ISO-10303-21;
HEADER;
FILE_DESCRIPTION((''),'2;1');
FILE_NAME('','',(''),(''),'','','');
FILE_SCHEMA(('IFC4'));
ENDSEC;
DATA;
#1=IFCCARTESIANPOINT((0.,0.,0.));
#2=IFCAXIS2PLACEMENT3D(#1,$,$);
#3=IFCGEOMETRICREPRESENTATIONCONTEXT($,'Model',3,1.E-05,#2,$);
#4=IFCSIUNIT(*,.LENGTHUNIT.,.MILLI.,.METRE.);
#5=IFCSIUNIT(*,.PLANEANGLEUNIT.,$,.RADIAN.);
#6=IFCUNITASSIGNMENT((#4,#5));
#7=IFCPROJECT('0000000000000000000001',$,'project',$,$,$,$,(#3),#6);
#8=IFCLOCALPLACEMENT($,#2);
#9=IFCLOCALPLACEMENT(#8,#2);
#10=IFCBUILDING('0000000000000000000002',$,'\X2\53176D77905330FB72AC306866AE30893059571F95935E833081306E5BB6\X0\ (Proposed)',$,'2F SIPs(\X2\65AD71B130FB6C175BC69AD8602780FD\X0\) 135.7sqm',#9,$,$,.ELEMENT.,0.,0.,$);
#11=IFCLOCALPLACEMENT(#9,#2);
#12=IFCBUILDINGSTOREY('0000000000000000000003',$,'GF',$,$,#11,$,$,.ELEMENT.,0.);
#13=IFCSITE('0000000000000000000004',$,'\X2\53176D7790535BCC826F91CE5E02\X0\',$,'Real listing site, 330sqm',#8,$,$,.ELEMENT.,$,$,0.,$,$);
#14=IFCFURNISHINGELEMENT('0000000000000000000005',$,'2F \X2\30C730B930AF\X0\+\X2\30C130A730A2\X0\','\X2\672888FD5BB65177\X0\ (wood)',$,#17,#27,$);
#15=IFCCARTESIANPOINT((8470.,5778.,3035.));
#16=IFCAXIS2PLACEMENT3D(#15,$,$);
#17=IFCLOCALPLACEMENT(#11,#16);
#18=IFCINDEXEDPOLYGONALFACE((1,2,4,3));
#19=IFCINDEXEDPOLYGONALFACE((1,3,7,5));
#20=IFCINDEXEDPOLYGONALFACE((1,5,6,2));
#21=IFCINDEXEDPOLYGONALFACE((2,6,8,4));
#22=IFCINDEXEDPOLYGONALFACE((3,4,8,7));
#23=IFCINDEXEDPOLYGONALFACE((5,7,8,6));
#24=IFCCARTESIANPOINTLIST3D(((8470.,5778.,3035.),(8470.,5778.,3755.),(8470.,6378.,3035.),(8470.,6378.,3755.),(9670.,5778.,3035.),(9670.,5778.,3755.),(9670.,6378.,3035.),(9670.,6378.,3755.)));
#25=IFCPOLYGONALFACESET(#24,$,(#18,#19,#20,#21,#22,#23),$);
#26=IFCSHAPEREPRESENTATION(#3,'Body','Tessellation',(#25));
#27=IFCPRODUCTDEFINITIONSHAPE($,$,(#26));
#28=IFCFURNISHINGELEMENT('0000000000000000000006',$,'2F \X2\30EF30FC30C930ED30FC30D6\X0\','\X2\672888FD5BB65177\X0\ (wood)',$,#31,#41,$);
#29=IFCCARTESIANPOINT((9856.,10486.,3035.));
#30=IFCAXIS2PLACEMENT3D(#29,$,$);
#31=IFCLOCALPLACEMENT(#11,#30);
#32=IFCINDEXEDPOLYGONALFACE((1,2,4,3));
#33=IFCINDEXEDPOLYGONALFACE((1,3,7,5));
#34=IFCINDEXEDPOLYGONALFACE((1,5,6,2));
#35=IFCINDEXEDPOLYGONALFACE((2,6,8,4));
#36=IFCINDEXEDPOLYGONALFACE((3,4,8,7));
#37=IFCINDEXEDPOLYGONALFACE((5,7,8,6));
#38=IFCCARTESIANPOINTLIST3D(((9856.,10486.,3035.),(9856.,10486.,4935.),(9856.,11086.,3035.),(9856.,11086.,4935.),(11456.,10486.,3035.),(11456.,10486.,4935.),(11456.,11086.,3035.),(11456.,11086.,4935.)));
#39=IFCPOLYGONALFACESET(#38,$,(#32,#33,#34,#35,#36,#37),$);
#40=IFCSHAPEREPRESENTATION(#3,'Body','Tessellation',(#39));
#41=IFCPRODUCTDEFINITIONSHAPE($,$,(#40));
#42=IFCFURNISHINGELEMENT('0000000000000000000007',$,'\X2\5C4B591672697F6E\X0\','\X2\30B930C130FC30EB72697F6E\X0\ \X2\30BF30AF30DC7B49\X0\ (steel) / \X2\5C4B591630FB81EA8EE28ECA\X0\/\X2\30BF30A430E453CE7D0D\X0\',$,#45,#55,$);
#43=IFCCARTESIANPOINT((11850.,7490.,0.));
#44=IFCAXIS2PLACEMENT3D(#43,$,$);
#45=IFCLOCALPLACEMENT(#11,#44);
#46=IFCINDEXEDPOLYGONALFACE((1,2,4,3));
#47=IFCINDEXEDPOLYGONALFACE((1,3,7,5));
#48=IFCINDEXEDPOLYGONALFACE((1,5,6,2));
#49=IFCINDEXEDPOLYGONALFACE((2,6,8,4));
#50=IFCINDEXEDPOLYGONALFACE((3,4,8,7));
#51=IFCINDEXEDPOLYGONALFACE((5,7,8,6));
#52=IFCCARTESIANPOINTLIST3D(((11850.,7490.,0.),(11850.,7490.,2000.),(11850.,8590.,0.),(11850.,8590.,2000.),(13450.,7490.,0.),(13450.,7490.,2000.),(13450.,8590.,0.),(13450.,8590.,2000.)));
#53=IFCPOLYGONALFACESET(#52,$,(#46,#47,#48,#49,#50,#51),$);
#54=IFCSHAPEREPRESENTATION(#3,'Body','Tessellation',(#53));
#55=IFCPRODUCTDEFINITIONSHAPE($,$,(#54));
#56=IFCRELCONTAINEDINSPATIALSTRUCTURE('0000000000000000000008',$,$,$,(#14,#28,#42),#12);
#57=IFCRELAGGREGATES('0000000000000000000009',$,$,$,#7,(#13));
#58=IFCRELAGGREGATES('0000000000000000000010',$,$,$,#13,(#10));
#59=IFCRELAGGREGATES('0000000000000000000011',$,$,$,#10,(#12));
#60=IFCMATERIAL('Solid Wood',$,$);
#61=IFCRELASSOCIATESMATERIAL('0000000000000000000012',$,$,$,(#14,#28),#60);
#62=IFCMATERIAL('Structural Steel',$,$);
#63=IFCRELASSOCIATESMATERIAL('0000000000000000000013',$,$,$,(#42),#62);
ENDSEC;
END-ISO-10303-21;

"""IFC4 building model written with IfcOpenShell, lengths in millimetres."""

from ifc_helpers import new_model, si_unit, frame, frame_2d, origin, place, context, project, spatial, rectangle, extrude, material, element, save


model = new_model("IFC4")

# Units and contexts
model_context = context("Model", 3, precision=1e-05, world=origin())
ifc_project = project(units=[si_unit("LENGTHUNIT", "METRE", prefix="MILLI"), si_unit("PLANEANGLEUNIT", "RADIAN")], contexts=[model_context])

# Site, building, storey
site_placement = place(None, origin())
site = spatial("IfcSite", under=ifc_project, at=site_placement, Name="北海道富良野市", ObjectType="Real listing site, 330sqm", CompositionType="ELEMENT", RefElevation=0.0)
building_placement = place(site_placement, origin())
building = spatial("IfcBuilding", under=site, at=building_placement, Name="北海道・犬と暮らす土間広めの家 (Proposed)", ObjectType="2F SIPs(断熱・気密高性能) 135.7sqm", CompositionType="ELEMENT", ElevationOfRefHeight=0.0, ElevationOfTerrain=0.0)
storey_placement = place(building_placement, origin())
storey = spatial("IfcBuildingStorey", under=building, at=storey_placement, Name="GF", CompositionType="ELEMENT", Elevation=0.0)

# Shared definitions
ifc_material_1 = material(Name="Solid Wood")

# Shared definitions
ifc_material_2 = material(Name="Structural Steel")

# Furnishing elements
furnishing_1_placement = place(storey_placement, frame((8470.0, 5778.0, 3035.0)))
element("IfcFurnishingElement", 1, at=furnishing_1_placement, inside=storey, material=ifc_material_1, Name="2F デスク+チェア", Description="木製家具 (wood)", context=model_context, shape_type="SweptSolid", body=[
    extrude(rectangle(XDim=1200.0, YDim=600.0, at=frame_2d((600.0, 300.0))), frame((8470.0, 5778.0, 3035.0)), (0.0, 0.0, 1.0), 720.0),
])
furnishing_2_placement = place(storey_placement, frame((9856.0, 10486.0, 3035.0)))
element("IfcFurnishingElement", 2, at=furnishing_2_placement, inside=storey, material=ifc_material_1, Name="2F ワードローブ", Description="木製家具 (wood)", context=model_context, shape_type="SweptSolid", body=[
    extrude(rectangle(XDim=1600.0, YDim=600.0, at=frame_2d((800.0, 300.0))), frame((9856.0, 10486.0, 3035.0)), (0.0, 0.0, 1.0), 1900.0),
])
furnishing_3_placement = place(storey_placement, frame((11850.0, 7490.0, 0.0)))
element("IfcFurnishingElement", 3, at=furnishing_3_placement, inside=storey, material=ifc_material_2, Name="屋外物置", Description="スチール物置 タクボ等 (steel) / 屋外・自転車/タイヤ収納", context=model_context, shape_type="SweptSolid", body=[
    extrude(rectangle(XDim=1600.0, YDim=1100.0, at=frame_2d((800.0, 550.0))), frame((11850.0, 7490.0, 0.0)), (0.0, 0.0, 1.0), 2000.0),
])

save(model, "model.ifc")
